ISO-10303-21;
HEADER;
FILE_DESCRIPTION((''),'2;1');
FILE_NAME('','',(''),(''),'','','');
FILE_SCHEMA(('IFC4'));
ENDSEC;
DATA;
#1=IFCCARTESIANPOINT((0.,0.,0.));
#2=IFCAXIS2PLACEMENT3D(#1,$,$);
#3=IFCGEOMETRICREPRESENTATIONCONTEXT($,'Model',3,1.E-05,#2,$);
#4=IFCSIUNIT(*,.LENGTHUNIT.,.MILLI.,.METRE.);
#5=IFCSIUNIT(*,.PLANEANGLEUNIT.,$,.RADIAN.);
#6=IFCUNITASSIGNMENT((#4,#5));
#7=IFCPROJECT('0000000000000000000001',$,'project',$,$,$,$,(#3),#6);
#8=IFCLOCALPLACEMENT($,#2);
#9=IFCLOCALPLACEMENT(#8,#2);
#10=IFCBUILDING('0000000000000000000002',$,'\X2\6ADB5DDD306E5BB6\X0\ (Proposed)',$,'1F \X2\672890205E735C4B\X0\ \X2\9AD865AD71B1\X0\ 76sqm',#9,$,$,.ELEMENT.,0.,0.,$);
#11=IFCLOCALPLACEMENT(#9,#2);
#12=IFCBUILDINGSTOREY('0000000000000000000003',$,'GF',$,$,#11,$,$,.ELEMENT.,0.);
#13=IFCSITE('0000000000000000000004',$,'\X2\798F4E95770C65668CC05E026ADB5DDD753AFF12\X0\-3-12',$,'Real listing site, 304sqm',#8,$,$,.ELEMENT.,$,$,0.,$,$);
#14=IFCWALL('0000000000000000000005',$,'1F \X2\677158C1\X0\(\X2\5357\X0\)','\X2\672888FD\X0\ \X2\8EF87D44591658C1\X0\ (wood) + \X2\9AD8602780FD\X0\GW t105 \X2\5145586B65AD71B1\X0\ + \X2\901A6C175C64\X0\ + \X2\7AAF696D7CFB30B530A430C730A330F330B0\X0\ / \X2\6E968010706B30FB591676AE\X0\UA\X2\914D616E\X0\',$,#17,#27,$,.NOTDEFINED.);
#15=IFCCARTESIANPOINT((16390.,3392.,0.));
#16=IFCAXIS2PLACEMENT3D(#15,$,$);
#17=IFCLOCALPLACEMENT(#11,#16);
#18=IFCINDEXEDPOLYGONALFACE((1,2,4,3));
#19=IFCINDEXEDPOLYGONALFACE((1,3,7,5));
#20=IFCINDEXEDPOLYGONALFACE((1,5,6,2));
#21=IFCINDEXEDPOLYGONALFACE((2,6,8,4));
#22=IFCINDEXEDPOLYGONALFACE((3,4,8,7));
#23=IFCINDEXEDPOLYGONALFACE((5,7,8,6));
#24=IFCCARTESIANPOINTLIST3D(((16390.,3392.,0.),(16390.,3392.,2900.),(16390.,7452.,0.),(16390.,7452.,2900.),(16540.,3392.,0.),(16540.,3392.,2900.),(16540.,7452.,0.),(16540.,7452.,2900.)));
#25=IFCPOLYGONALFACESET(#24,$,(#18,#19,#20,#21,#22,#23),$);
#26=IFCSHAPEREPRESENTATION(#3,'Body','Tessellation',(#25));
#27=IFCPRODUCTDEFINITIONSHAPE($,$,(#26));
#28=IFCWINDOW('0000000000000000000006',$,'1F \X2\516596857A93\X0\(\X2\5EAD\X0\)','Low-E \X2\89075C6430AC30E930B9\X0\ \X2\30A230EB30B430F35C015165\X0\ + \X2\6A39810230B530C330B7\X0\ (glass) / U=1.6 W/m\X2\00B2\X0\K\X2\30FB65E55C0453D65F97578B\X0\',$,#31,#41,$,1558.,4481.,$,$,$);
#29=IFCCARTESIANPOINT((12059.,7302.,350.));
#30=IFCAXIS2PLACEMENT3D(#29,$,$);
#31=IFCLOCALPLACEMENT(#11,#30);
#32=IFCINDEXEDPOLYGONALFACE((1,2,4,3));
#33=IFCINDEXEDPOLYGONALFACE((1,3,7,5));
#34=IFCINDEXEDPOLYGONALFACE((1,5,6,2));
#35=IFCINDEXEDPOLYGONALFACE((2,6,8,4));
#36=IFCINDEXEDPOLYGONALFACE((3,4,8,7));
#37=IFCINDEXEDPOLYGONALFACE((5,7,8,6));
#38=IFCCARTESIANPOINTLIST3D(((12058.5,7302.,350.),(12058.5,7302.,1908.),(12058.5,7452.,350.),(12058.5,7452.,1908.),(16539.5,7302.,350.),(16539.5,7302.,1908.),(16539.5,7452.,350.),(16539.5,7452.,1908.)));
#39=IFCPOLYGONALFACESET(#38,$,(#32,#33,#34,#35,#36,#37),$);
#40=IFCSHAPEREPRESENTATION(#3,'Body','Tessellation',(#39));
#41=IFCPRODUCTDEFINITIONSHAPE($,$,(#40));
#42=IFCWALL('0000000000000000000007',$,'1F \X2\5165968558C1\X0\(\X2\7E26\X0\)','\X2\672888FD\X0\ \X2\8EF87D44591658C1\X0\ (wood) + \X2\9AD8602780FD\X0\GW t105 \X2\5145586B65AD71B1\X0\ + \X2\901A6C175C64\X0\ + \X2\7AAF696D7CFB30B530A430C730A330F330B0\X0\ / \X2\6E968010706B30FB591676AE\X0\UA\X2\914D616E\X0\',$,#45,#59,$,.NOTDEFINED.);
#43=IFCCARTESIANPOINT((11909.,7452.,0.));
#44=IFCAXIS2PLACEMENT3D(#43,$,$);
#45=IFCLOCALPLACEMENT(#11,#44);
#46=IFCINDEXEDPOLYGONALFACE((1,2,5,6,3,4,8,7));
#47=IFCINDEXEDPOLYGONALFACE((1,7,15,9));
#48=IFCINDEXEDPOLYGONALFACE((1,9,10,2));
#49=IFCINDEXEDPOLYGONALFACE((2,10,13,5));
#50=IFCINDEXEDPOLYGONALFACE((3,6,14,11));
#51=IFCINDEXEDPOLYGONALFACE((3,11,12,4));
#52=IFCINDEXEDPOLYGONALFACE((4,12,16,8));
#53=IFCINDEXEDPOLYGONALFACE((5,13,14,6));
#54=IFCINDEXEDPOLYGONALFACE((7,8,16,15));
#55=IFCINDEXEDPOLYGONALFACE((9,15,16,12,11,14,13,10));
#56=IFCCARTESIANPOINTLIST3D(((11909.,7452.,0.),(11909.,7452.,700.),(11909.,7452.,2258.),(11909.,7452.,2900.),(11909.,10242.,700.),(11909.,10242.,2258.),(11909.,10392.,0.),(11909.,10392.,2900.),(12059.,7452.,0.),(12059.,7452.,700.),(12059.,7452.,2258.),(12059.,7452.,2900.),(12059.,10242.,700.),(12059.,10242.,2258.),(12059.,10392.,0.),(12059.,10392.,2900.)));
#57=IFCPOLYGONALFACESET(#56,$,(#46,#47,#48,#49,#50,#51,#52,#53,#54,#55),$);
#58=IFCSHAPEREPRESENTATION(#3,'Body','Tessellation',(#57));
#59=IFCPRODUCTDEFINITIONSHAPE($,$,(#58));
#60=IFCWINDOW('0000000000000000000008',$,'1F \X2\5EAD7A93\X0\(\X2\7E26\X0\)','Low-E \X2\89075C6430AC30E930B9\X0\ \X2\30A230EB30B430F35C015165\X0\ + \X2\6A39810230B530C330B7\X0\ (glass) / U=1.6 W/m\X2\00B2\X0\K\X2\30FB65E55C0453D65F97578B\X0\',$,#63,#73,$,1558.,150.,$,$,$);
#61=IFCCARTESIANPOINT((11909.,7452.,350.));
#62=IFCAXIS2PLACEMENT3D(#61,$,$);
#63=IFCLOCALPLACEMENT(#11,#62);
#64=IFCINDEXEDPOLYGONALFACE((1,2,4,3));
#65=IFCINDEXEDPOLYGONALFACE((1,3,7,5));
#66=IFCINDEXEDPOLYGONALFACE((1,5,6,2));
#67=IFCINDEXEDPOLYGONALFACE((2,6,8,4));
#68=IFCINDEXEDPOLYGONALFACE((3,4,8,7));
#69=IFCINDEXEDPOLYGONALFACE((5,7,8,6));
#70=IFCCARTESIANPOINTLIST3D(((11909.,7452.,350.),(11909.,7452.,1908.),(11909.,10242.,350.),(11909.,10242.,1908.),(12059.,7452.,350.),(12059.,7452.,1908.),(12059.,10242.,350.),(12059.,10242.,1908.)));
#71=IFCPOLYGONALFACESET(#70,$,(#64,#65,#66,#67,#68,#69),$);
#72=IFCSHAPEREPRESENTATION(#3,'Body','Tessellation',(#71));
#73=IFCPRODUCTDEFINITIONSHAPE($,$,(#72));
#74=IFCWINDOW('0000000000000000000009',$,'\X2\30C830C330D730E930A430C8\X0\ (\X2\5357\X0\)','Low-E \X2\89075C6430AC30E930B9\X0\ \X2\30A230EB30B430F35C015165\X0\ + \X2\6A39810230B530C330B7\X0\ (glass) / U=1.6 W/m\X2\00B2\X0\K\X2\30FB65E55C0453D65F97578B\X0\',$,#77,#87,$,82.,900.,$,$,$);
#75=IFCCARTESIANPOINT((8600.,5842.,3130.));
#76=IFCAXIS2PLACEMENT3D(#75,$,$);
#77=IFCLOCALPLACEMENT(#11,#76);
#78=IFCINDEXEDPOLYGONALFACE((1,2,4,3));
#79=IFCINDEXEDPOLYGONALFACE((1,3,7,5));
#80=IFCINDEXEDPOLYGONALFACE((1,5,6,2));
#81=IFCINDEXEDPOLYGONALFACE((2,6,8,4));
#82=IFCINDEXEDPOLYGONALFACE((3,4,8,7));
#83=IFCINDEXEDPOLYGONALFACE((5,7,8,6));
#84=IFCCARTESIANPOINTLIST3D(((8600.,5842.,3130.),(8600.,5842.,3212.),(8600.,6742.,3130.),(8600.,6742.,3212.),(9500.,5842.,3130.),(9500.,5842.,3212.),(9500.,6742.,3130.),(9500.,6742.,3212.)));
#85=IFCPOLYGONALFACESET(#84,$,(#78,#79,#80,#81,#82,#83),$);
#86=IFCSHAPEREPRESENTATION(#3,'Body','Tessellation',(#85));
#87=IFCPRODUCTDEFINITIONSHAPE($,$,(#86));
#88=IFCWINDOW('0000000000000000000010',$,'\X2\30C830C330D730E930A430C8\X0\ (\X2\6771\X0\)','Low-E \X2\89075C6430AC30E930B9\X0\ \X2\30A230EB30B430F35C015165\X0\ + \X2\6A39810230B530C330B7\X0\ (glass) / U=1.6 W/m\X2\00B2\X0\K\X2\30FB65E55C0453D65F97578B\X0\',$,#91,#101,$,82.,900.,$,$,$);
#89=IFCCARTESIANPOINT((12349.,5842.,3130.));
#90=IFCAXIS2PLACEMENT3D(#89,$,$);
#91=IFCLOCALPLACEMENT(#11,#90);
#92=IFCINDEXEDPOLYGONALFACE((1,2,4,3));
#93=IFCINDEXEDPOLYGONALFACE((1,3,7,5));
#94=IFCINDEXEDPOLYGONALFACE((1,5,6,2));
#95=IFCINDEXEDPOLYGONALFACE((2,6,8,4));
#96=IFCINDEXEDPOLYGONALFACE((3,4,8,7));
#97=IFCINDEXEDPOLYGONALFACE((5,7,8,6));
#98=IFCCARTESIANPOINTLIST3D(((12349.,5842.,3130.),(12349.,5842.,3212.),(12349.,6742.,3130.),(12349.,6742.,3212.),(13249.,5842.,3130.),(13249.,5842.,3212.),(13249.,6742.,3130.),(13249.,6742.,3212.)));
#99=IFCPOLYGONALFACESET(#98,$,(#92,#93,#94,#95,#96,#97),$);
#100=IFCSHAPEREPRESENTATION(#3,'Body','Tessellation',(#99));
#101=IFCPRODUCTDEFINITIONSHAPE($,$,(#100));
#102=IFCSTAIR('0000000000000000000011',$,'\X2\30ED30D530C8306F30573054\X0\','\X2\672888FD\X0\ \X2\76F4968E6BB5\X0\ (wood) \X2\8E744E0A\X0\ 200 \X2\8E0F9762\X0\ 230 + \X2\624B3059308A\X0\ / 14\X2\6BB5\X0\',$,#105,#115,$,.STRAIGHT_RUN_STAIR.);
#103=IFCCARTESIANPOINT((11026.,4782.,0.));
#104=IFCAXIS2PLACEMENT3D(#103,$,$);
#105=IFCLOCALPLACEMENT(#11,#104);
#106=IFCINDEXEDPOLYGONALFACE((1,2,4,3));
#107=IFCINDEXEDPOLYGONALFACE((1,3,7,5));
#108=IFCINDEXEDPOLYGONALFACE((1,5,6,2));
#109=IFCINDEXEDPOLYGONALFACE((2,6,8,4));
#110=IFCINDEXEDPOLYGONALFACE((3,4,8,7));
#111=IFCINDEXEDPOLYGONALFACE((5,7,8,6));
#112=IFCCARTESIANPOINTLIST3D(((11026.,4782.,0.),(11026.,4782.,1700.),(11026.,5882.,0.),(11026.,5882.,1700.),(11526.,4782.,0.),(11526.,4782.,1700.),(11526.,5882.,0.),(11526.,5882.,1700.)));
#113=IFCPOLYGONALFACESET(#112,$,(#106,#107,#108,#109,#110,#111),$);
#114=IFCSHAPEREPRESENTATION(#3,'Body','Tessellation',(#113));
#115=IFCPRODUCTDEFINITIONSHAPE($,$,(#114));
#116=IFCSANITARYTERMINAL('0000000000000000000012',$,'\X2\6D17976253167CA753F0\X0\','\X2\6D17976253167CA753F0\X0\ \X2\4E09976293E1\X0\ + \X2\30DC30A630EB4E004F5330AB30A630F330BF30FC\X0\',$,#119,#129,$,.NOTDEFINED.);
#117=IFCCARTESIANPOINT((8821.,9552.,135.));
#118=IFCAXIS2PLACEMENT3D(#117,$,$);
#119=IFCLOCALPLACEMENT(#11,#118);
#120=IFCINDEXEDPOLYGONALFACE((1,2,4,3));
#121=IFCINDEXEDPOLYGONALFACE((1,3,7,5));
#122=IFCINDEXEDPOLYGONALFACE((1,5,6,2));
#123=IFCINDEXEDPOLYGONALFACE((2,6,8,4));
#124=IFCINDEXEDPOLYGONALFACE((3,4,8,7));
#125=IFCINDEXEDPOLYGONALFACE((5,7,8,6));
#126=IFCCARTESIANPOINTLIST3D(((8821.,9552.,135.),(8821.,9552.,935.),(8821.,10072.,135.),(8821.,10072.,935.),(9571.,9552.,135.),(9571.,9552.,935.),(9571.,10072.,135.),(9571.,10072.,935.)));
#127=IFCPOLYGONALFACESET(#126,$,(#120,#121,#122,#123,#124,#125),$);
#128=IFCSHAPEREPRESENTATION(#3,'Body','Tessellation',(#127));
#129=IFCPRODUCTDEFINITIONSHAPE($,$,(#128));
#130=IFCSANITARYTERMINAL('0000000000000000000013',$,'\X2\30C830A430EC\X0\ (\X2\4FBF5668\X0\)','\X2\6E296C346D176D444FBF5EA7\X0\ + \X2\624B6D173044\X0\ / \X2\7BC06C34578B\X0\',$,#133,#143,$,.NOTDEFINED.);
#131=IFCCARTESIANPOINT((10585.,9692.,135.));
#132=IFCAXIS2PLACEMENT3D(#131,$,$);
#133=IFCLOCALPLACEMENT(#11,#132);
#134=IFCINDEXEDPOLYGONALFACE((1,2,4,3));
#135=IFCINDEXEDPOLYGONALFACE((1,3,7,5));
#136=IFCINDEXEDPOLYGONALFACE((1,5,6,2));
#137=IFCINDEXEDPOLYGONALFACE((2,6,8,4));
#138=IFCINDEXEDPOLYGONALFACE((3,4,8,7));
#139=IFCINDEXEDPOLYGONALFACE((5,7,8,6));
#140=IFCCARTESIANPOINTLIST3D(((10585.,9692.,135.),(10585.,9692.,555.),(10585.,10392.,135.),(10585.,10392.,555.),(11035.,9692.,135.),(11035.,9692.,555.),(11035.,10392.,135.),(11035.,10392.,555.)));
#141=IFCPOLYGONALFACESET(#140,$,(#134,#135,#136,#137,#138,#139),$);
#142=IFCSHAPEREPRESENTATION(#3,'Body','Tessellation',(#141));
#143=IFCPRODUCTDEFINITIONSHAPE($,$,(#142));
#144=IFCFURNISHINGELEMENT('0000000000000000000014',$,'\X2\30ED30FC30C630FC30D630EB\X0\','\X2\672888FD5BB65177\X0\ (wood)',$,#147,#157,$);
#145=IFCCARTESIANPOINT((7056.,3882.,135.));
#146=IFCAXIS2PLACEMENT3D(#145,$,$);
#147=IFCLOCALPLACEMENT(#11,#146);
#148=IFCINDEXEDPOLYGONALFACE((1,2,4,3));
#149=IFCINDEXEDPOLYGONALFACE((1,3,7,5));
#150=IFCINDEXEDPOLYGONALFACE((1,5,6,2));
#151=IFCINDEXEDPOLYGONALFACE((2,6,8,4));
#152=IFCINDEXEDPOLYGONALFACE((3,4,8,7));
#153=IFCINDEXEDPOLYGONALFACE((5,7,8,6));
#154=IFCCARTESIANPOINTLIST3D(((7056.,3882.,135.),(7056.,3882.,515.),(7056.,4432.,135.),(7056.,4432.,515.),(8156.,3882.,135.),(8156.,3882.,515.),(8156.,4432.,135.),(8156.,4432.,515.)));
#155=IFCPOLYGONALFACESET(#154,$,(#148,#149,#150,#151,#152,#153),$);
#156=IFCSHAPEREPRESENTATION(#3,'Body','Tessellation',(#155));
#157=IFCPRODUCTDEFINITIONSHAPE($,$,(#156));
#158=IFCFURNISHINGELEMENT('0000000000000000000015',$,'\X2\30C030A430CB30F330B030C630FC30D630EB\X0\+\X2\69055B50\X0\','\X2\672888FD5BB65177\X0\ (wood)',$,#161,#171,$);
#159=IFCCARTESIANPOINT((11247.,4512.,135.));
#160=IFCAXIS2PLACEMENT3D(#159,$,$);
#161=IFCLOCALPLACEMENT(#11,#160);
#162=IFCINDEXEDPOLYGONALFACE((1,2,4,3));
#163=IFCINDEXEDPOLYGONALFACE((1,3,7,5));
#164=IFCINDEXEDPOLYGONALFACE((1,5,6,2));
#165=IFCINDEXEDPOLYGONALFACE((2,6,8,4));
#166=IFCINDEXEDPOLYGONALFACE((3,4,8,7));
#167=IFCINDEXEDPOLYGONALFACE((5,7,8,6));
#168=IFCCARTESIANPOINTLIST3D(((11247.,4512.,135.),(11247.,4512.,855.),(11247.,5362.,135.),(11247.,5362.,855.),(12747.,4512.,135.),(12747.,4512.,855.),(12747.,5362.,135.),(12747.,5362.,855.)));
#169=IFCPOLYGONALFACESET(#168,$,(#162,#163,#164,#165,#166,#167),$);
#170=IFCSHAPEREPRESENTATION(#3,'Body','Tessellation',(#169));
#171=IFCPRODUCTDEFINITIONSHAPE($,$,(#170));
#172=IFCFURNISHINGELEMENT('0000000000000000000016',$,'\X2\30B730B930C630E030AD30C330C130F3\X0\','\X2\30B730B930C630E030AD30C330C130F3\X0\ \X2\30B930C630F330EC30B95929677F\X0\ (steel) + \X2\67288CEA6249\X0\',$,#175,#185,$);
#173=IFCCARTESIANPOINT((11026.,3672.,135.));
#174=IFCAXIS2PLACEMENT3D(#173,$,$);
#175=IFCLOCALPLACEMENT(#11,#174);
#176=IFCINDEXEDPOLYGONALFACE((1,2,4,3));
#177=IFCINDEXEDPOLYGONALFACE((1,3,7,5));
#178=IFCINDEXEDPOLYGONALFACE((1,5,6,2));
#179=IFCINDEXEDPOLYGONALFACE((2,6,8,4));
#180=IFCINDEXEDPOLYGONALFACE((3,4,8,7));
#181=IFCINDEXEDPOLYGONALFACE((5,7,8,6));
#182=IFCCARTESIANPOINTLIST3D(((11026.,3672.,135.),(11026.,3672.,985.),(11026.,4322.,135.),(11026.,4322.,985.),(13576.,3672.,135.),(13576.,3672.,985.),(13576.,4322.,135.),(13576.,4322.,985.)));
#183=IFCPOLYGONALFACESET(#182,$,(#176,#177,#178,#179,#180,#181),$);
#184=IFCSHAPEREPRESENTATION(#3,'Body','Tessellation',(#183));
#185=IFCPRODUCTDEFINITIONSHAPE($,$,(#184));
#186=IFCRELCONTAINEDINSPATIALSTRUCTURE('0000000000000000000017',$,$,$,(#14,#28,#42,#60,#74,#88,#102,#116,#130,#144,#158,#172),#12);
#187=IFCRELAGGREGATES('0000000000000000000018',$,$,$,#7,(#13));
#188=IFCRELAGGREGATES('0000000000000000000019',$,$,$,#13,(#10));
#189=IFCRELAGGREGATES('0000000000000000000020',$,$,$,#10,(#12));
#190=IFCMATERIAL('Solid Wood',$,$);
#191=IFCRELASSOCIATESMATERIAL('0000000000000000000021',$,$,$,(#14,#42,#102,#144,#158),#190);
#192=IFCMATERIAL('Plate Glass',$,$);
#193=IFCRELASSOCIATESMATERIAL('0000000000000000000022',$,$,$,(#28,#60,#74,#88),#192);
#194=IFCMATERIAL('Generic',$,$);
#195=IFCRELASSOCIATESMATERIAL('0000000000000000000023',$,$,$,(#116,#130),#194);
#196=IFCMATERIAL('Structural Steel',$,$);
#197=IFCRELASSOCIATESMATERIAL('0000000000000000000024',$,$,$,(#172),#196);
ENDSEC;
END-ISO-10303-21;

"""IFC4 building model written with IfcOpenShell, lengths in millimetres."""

from ifc_helpers import new_model, si_unit, frame, frame_2d, origin, place, context, project, spatial, rectangle, extrude, material, element, fill, save


model = new_model("IFC4")

# Units and contexts
model_context = context("Model", 3, precision=1e-05, world=origin())
ifc_project = project(units=[si_unit("LENGTHUNIT", "METRE", prefix="MILLI"), si_unit("PLANEANGLEUNIT", "RADIAN")], contexts=[model_context])

# Site, building, storey
site_placement = place(None, origin())
site = spatial("IfcSite", under=ifc_project, at=site_placement, Name="福井県敦賀市櫛川町２-3-12", ObjectType="Real listing site, 304sqm", CompositionType="ELEMENT", RefElevation=0.0)
building_placement = place(site_placement, origin())
building = spatial("IfcBuilding", under=site, at=building_placement, Name="櫛川の家 (Proposed)", ObjectType="1F 木造平屋 高断熱 76sqm", CompositionType="ELEMENT", ElevationOfRefHeight=0.0, ElevationOfTerrain=0.0)
storey_placement = place(building_placement, origin())
storey = spatial("IfcBuildingStorey", under=building, at=storey_placement, Name="GF", CompositionType="ELEMENT", Elevation=0.0)

# Shared definitions
ifc_material_1 = material(Name="Solid Wood")

# Wall, opening, window
wall_1_placement = place(storey_placement, frame((16390.0, 3392.0, 0.0)))
wall_1 = element("IfcWall", 1, at=wall_1_placement, inside=storey, material=ifc_material_1, Name="1F 東壁(南)", Description="木製 軸組外壁 (wood) + 高性能GW t105 充填断熱 + 通気層 + 窯業系サイディング / 準耐火・外皮UA配慮", PredefinedType="NOTDEFINED", context=model_context, shape_type="SweptSolid", body=[
    extrude(rectangle(XDim=150.0, YDim=4060.0, at=frame_2d((75.0, 2030.0))), frame((16390.0, 3392.0, 0.0)), (0.0, 0.0, 1.0), 2900.0),
])
opening_1_placement = place(storey_placement, frame((12059.0, 7302.0, 350.0)))
opening_1 = element("IfcOpeningElement", 2, at=opening_1_placement, cuts=wall_1, PredefinedType="NOTDEFINED", context=model_context, shape_type="SweptSolid", body=[
    extrude(rectangle(XDim=4481.0, YDim=150.0, at=frame_2d((2240.0, 75.0))), frame((12059.0, 7302.0, 350.0)), (0.0, 0.0, 1.0), 1558.0),
])
ifc_material_2 = material(Name="Plate Glass")
window_1_placement = place(storey_placement, frame((12059.0, 7302.0, 350.0)))
window_1 = element("IfcWindow", 3, at=window_1_placement, inside=storey, material=ifc_material_2, Name="1F 入隅窓(庭)", Description="Low-E 複層ガラス アルゴン封入 + 樹脂サッシ (glass) / U=1.6 W/m²K・日射取得型", OverallHeight=1558.0, OverallWidth=4481.0, context=model_context, shape_type="SweptSolid", body=[
    extrude(rectangle(XDim=4481.0, YDim=150.0, at=frame_2d((2240.0, 75.0))), frame((12059.0, 7302.0, 350.0)), (0.0, 0.0, 1.0), 1558.0),
])
fill(opening_1, window_1)

# Wall, opening, window
wall_2_placement = place(storey_placement, frame((11909.0, 7452.0, 0.0)))
wall_2 = element("IfcWall", 4, at=wall_2_placement, inside=storey, material=ifc_material_1, Name="1F 入隅壁(縦)", Description="木製 軸組外壁 (wood) + 高性能GW t105 充填断熱 + 通気層 + 窯業系サイディング / 準耐火・外皮UA配慮", PredefinedType="NOTDEFINED", context=model_context, shape_type="SweptSolid", body=[
    extrude(rectangle(XDim=150.0, YDim=2940.0, at=frame_2d((75.0, 1470.0))), frame((11909.0, 7452.0, 0.0)), (0.0, 0.0, 1.0), 2900.0),
])
opening_2_placement = place(storey_placement, frame((11909.0, 7452.0, 350.0)))
opening_2 = element("IfcOpeningElement", 5, at=opening_2_placement, cuts=wall_2, PredefinedType="NOTDEFINED", context=model_context, shape_type="SweptSolid", body=[
    extrude(rectangle(XDim=150.0, YDim=2790.0, at=frame_2d((75.0, 1395.0))), frame((11909.0, 7452.0, 350.0)), (0.0, 0.0, 1.0), 1558.0),
])
window_2_placement = place(storey_placement, frame((11909.0, 7452.0, 350.0)))
window_2 = element("IfcWindow", 6, at=window_2_placement, inside=storey, material=ifc_material_2, Name="1F 庭窓(縦)", Description="Low-E 複層ガラス アルゴン封入 + 樹脂サッシ (glass) / U=1.6 W/m²K・日射取得型", OverallHeight=1558.0, OverallWidth=150.0, context=model_context, shape_type="SweptSolid", body=[
    extrude(rectangle(XDim=150.0, YDim=2790.0, at=frame_2d((75.0, 1395.0))), frame((11909.0, 7452.0, 350.0)), (0.0, 0.0, 1.0), 1558.0),
])
fill(opening_2, window_2)

# Windows
window_3_placement = place(storey_placement, frame((8600.0, 5842.0, 3130.0)))
element("IfcWindow", 7, at=window_3_placement, inside=storey, material=ifc_material_2, Name="トップライト (南)", Description="Low-E 複層ガラス アルゴン封入 + 樹脂サッシ (glass) / U=1.6 W/m²K・日射取得型", OverallHeight=82.0, OverallWidth=900.0, context=model_context, shape_type="SweptSolid", body=[
    extrude(rectangle(XDim=900.0, YDim=900.0, at=frame_2d((450.0, 450.0))), frame((8600.0, 5842.0, 3130.0)), (0.0, 0.0, 1.0), 82.0),
])
window_4_placement = place(storey_placement, frame((12349.0, 5842.0, 3130.0)))
element("IfcWindow", 8, at=window_4_placement, inside=storey, material=ifc_material_2, Name="トップライト (東)", Description="Low-E 複層ガラス アルゴン封入 + 樹脂サッシ (glass) / U=1.6 W/m²K・日射取得型", OverallHeight=82.0, OverallWidth=900.0, context=model_context, shape_type="SweptSolid", body=[
    extrude(rectangle(XDim=900.0, YDim=900.0, at=frame_2d((450.0, 450.0))), frame((12349.0, 5842.0, 3130.0)), (0.0, 0.0, 1.0), 82.0),
])

# Stair
stair_placement = place(storey_placement, frame((11026.0, 4782.0, 0.0)))
element("IfcStair", 9, at=stair_placement, inside=storey, material=ifc_material_1, Name="ロフトはしご", Description="木製 直階段 (wood) 蹴上 200 踏面 230 + 手すり / 14段", PredefinedType="STRAIGHT_RUN_STAIR", context=model_context, shape_type="SweptSolid", body=[
    extrude(rectangle(XDim=500.0, YDim=1100.0, at=frame_2d((250.0, 550.0))), frame((11026.0, 4782.0, 0.0)), (0.0, 0.0, 1.0), 1700.0),
])

# Sanitary terminals
ifc_material_3 = material(Name="Generic")
sanitary_terminal_1_placement = place(storey_placement, frame((8821.0, 9552.0, 135.0)))
element("IfcSanitaryTerminal", 10, at=sanitary_terminal_1_placement, inside=storey, material=ifc_material_3, Name="洗面化粧台", Description="洗面化粧台 三面鏡 + ボウル一体カウンター", PredefinedType="NOTDEFINED", context=model_context, shape_type="SweptSolid", body=[
    extrude(rectangle(XDim=750.0, YDim=520.0, at=frame_2d((375.0, 260.0))), frame((8821.0, 9552.0, 135.0)), (0.0, 0.0, 1.0), 800.0),
])
sanitary_terminal_2_placement = place(storey_placement, frame((10585.0, 9692.0, 135.0)))
element("IfcSanitaryTerminal", 11, at=sanitary_terminal_2_placement, inside=storey, material=ifc_material_3, Name="トイレ (便器)", Description="温水洗浄便座 + 手洗い / 節水型", PredefinedType="NOTDEFINED", context=model_context, shape_type="SweptSolid", body=[
    extrude(rectangle(XDim=450.0, YDim=700.0, at=frame_2d((225.0, 350.0))), frame((10585.0, 9692.0, 135.0)), (0.0, 0.0, 1.0), 420.0),
])

# Furnishing elements
furnishing_1_placement = place(storey_placement, frame((7056.0, 3882.0, 135.0)))
element("IfcFurnishingElement", 12, at=furnishing_1_placement, inside=storey, material=ifc_material_1, Name="ローテーブル", Description="木製家具 (wood)", context=model_context, shape_type="SweptSolid", body=[
    extrude(rectangle(XDim=1100.0, YDim=550.0, at=frame_2d((550.0, 275.0))), frame((7056.0, 3882.0, 135.0)), (0.0, 0.0, 1.0), 380.0),
])
furnishing_2_placement = place(storey_placement, frame((11247.0, 4512.0, 135.0)))
element("IfcFurnishingElement", 13, at=furnishing_2_placement, inside=storey, material=ifc_material_1, Name="ダイニングテーブル+椅子", Description="木製家具 (wood)", context=model_context, shape_type="SweptSolid", body=[
    extrude(rectangle(XDim=1500.0, YDim=850.0, at=frame_2d((750.0, 425.0))), frame((11247.0, 4512.0, 135.0)), (0.0, 0.0, 1.0), 720.0),
])
ifc_material_4 = material(Name="Structural Steel")
furnishing_3_placement = place(storey_placement, frame((11026.0, 3672.0, 135.0)))
element("IfcFurnishingElement", 14, at=furnishing_3_placement, inside=storey, material=ifc_material_4, Name="システムキッチン", Description="システムキッチン ステンレス天板 (steel) + 木質扉", context=model_context, shape_type="SweptSolid", body=[
    extrude(rectangle(XDim=2550.0, YDim=650.0, at=frame_2d((1275.0, 325.0))), frame((11026.0, 3672.0, 135.0)), (0.0, 0.0, 1.0), 850.0),
])

save(model, "model.ifc")
